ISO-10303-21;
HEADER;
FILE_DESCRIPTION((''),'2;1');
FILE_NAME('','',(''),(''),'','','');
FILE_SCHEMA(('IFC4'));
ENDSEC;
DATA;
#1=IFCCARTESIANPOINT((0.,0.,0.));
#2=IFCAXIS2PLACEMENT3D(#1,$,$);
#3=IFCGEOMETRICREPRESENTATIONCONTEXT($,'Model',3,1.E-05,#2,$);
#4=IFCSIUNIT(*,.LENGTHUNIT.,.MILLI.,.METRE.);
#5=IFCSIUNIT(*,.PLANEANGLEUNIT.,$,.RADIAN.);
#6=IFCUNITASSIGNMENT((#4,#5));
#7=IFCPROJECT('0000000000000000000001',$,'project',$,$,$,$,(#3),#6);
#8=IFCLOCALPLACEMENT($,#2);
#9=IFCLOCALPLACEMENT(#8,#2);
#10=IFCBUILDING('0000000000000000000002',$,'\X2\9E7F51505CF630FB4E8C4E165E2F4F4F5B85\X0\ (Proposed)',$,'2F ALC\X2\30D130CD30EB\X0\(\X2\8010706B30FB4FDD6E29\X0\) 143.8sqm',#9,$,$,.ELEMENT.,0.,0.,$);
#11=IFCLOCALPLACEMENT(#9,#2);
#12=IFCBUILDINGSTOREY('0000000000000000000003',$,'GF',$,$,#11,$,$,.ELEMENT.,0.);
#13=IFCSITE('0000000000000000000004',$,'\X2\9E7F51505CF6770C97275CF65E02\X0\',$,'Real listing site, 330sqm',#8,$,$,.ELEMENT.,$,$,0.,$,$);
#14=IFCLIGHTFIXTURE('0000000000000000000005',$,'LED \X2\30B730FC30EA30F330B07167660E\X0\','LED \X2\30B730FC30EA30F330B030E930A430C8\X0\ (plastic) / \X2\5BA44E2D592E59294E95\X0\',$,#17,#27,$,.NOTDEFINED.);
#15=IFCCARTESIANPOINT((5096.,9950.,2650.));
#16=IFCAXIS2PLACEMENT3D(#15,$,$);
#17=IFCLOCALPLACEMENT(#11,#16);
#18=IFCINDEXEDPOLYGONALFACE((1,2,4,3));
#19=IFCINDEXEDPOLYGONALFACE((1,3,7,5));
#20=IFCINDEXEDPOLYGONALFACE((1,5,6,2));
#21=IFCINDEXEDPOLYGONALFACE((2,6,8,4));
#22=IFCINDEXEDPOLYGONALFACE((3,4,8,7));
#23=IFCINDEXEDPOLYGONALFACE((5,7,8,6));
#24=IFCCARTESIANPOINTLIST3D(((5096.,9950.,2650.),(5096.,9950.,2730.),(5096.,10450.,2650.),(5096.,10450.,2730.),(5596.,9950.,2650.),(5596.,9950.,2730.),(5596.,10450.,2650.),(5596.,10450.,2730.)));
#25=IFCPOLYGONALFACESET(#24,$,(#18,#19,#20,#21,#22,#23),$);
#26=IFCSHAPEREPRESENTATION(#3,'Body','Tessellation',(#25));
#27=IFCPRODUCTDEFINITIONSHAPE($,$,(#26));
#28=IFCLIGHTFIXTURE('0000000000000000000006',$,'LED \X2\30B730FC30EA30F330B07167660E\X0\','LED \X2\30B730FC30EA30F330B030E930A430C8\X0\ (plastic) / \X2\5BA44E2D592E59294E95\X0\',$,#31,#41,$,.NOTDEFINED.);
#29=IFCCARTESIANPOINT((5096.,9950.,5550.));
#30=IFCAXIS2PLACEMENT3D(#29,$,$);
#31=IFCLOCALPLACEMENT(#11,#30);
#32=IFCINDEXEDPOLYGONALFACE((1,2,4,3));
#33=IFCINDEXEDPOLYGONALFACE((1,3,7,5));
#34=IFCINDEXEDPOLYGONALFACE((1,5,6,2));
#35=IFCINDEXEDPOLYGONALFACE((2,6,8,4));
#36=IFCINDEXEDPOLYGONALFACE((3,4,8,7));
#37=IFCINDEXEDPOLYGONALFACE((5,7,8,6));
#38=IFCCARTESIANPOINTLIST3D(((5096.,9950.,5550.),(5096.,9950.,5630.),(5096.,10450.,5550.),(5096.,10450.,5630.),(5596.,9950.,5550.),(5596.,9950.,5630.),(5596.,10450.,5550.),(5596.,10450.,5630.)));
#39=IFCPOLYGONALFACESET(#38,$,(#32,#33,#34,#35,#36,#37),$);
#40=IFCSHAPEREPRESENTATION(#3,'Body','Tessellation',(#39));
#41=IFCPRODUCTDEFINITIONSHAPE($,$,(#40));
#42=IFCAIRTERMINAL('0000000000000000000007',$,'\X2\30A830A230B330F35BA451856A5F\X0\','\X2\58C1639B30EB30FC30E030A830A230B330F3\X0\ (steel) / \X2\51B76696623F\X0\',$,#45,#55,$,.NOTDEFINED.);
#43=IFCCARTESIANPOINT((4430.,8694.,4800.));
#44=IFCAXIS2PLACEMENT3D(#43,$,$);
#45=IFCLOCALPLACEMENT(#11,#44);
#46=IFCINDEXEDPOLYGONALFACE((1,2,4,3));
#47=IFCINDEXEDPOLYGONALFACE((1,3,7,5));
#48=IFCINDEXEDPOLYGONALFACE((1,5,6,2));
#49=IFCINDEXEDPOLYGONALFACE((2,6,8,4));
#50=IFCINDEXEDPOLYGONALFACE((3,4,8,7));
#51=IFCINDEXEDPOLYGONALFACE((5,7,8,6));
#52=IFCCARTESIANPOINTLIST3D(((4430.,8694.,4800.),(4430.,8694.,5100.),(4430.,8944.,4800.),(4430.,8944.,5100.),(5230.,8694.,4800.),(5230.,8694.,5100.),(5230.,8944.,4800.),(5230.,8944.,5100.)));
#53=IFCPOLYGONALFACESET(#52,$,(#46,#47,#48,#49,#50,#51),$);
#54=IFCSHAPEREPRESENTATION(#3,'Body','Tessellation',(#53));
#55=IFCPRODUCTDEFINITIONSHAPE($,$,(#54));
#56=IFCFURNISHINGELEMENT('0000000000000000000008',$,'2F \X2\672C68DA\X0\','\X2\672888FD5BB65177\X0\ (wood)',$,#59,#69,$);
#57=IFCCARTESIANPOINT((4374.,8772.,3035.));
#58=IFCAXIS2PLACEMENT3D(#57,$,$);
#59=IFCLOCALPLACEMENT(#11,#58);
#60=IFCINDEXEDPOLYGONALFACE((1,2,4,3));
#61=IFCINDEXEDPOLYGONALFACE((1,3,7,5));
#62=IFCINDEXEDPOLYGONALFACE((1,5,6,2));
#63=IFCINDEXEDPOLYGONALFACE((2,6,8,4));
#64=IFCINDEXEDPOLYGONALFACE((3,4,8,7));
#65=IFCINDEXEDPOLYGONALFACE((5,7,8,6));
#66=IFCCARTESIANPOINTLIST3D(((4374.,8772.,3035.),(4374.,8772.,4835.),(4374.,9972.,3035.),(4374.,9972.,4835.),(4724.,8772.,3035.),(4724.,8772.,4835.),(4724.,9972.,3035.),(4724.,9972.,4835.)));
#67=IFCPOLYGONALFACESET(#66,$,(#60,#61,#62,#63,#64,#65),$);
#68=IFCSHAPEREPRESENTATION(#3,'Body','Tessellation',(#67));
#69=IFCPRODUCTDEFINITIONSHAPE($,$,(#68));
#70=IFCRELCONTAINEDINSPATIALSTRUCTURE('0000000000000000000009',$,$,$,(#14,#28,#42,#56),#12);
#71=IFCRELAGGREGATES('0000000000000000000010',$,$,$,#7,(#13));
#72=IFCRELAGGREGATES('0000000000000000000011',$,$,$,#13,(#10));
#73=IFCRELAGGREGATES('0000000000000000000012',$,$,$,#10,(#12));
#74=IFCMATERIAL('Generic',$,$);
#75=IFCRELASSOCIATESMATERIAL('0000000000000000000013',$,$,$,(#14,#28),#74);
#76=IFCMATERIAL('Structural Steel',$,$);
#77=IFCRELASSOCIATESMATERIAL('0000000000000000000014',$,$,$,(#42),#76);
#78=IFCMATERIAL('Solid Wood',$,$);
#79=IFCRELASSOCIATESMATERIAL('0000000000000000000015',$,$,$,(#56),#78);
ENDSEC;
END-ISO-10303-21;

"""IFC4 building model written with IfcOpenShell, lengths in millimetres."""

from ifc_helpers import new_model, si_unit, frame, frame_2d, origin, place, context, project, spatial, rectangle, extrude, material, element, save


model = new_model("IFC4")

# Units and contexts
model_context = context("Model", 3, precision=1e-05, world=origin())
ifc_project = project(units=[si_unit("LENGTHUNIT", "METRE", prefix="MILLI"), si_unit("PLANEANGLEUNIT", "RADIAN")], contexts=[model_context])

# Site, building, storey
site_placement = place(None, origin())
site = spatial("IfcSite", under=ifc_project, at=site_placement, Name="鹿児島県霧島市", ObjectType="Real listing site, 330sqm", CompositionType="ELEMENT", RefElevation=0.0)
building_placement = place(site_placement, origin())
building = spatial("IfcBuilding", under=site, at=building_placement, Name="鹿児島・二世帯住宅 (Proposed)", ObjectType="2F ALCパネル(耐火・保温) 143.8sqm", CompositionType="ELEMENT", ElevationOfRefHeight=0.0, ElevationOfTerrain=0.0)
storey_placement = place(building_placement, origin())
storey = spatial("IfcBuildingStorey", under=building, at=storey_placement, Name="GF", CompositionType="ELEMENT", Elevation=0.0)

# Shared definitions
ifc_material_1 = material(Name="Solid Wood")

# Shared definitions
ifc_material_2 = material(Name="Structural Steel")

# Shared definitions
ifc_material_3 = material(Name="Generic")

# Light fixtures
light_fixture_1_placement = place(storey_placement, frame((5096.0, 9950.0, 2650.0)))
element("IfcLightFixture", 1, at=light_fixture_1_placement, inside=storey, material=ifc_material_3, Name="LED シーリング照明", Description="LED シーリングライト (plastic) / 室中央天井", PredefinedType="NOTDEFINED", context=model_context, shape_type="SweptSolid", body=[
    extrude(rectangle(XDim=500.0, YDim=500.0, at=frame_2d((250.0, 250.0))), frame((5096.0, 9950.0, 2650.0)), (0.0, 0.0, 1.0), 80.0),
])
light_fixture_2_placement = place(storey_placement, frame((5096.0, 9950.0, 5550.0)))
element("IfcLightFixture", 2, at=light_fixture_2_placement, inside=storey, material=ifc_material_3, Name="LED シーリング照明", Description="LED シーリングライト (plastic) / 室中央天井", PredefinedType="NOTDEFINED", context=model_context, shape_type="SweptSolid", body=[
    extrude(rectangle(XDim=500.0, YDim=500.0, at=frame_2d((250.0, 250.0))), frame((5096.0, 9950.0, 5550.0)), (0.0, 0.0, 1.0), 80.0),
])

# Air terminal
air_terminal_placement = place(storey_placement, frame((4430.0, 8694.0, 4800.0)))
element("IfcAirTerminal", 3, at=air_terminal_placement, inside=storey, material=ifc_material_2, Name="エアコン室内機", Description="壁掛ルームエアコン (steel) / 冷暖房", PredefinedType="NOTDEFINED", context=model_context, shape_type="SweptSolid", body=[
    extrude(rectangle(XDim=800.0, YDim=250.0, at=frame_2d((400.0, 125.0))), frame((4430.0, 8694.0, 4800.0)), (0.0, 0.0, 1.0), 300.0),
])

# Furnishing element
furnishing_placement = place(storey_placement, frame((4374.0, 8772.0, 3035.0)))
element("IfcFurnishingElement", 4, at=furnishing_placement, inside=storey, material=ifc_material_1, Name="2F 本棚", Description="木製家具 (wood)", context=model_context, shape_type="SweptSolid", body=[
    extrude(rectangle(XDim=350.0, YDim=1200.0, at=frame_2d((175.0, 600.0))), frame((4374.0, 8772.0, 3035.0)), (0.0, 0.0, 1.0), 1800.0),
])

save(model, "model.ifc")
